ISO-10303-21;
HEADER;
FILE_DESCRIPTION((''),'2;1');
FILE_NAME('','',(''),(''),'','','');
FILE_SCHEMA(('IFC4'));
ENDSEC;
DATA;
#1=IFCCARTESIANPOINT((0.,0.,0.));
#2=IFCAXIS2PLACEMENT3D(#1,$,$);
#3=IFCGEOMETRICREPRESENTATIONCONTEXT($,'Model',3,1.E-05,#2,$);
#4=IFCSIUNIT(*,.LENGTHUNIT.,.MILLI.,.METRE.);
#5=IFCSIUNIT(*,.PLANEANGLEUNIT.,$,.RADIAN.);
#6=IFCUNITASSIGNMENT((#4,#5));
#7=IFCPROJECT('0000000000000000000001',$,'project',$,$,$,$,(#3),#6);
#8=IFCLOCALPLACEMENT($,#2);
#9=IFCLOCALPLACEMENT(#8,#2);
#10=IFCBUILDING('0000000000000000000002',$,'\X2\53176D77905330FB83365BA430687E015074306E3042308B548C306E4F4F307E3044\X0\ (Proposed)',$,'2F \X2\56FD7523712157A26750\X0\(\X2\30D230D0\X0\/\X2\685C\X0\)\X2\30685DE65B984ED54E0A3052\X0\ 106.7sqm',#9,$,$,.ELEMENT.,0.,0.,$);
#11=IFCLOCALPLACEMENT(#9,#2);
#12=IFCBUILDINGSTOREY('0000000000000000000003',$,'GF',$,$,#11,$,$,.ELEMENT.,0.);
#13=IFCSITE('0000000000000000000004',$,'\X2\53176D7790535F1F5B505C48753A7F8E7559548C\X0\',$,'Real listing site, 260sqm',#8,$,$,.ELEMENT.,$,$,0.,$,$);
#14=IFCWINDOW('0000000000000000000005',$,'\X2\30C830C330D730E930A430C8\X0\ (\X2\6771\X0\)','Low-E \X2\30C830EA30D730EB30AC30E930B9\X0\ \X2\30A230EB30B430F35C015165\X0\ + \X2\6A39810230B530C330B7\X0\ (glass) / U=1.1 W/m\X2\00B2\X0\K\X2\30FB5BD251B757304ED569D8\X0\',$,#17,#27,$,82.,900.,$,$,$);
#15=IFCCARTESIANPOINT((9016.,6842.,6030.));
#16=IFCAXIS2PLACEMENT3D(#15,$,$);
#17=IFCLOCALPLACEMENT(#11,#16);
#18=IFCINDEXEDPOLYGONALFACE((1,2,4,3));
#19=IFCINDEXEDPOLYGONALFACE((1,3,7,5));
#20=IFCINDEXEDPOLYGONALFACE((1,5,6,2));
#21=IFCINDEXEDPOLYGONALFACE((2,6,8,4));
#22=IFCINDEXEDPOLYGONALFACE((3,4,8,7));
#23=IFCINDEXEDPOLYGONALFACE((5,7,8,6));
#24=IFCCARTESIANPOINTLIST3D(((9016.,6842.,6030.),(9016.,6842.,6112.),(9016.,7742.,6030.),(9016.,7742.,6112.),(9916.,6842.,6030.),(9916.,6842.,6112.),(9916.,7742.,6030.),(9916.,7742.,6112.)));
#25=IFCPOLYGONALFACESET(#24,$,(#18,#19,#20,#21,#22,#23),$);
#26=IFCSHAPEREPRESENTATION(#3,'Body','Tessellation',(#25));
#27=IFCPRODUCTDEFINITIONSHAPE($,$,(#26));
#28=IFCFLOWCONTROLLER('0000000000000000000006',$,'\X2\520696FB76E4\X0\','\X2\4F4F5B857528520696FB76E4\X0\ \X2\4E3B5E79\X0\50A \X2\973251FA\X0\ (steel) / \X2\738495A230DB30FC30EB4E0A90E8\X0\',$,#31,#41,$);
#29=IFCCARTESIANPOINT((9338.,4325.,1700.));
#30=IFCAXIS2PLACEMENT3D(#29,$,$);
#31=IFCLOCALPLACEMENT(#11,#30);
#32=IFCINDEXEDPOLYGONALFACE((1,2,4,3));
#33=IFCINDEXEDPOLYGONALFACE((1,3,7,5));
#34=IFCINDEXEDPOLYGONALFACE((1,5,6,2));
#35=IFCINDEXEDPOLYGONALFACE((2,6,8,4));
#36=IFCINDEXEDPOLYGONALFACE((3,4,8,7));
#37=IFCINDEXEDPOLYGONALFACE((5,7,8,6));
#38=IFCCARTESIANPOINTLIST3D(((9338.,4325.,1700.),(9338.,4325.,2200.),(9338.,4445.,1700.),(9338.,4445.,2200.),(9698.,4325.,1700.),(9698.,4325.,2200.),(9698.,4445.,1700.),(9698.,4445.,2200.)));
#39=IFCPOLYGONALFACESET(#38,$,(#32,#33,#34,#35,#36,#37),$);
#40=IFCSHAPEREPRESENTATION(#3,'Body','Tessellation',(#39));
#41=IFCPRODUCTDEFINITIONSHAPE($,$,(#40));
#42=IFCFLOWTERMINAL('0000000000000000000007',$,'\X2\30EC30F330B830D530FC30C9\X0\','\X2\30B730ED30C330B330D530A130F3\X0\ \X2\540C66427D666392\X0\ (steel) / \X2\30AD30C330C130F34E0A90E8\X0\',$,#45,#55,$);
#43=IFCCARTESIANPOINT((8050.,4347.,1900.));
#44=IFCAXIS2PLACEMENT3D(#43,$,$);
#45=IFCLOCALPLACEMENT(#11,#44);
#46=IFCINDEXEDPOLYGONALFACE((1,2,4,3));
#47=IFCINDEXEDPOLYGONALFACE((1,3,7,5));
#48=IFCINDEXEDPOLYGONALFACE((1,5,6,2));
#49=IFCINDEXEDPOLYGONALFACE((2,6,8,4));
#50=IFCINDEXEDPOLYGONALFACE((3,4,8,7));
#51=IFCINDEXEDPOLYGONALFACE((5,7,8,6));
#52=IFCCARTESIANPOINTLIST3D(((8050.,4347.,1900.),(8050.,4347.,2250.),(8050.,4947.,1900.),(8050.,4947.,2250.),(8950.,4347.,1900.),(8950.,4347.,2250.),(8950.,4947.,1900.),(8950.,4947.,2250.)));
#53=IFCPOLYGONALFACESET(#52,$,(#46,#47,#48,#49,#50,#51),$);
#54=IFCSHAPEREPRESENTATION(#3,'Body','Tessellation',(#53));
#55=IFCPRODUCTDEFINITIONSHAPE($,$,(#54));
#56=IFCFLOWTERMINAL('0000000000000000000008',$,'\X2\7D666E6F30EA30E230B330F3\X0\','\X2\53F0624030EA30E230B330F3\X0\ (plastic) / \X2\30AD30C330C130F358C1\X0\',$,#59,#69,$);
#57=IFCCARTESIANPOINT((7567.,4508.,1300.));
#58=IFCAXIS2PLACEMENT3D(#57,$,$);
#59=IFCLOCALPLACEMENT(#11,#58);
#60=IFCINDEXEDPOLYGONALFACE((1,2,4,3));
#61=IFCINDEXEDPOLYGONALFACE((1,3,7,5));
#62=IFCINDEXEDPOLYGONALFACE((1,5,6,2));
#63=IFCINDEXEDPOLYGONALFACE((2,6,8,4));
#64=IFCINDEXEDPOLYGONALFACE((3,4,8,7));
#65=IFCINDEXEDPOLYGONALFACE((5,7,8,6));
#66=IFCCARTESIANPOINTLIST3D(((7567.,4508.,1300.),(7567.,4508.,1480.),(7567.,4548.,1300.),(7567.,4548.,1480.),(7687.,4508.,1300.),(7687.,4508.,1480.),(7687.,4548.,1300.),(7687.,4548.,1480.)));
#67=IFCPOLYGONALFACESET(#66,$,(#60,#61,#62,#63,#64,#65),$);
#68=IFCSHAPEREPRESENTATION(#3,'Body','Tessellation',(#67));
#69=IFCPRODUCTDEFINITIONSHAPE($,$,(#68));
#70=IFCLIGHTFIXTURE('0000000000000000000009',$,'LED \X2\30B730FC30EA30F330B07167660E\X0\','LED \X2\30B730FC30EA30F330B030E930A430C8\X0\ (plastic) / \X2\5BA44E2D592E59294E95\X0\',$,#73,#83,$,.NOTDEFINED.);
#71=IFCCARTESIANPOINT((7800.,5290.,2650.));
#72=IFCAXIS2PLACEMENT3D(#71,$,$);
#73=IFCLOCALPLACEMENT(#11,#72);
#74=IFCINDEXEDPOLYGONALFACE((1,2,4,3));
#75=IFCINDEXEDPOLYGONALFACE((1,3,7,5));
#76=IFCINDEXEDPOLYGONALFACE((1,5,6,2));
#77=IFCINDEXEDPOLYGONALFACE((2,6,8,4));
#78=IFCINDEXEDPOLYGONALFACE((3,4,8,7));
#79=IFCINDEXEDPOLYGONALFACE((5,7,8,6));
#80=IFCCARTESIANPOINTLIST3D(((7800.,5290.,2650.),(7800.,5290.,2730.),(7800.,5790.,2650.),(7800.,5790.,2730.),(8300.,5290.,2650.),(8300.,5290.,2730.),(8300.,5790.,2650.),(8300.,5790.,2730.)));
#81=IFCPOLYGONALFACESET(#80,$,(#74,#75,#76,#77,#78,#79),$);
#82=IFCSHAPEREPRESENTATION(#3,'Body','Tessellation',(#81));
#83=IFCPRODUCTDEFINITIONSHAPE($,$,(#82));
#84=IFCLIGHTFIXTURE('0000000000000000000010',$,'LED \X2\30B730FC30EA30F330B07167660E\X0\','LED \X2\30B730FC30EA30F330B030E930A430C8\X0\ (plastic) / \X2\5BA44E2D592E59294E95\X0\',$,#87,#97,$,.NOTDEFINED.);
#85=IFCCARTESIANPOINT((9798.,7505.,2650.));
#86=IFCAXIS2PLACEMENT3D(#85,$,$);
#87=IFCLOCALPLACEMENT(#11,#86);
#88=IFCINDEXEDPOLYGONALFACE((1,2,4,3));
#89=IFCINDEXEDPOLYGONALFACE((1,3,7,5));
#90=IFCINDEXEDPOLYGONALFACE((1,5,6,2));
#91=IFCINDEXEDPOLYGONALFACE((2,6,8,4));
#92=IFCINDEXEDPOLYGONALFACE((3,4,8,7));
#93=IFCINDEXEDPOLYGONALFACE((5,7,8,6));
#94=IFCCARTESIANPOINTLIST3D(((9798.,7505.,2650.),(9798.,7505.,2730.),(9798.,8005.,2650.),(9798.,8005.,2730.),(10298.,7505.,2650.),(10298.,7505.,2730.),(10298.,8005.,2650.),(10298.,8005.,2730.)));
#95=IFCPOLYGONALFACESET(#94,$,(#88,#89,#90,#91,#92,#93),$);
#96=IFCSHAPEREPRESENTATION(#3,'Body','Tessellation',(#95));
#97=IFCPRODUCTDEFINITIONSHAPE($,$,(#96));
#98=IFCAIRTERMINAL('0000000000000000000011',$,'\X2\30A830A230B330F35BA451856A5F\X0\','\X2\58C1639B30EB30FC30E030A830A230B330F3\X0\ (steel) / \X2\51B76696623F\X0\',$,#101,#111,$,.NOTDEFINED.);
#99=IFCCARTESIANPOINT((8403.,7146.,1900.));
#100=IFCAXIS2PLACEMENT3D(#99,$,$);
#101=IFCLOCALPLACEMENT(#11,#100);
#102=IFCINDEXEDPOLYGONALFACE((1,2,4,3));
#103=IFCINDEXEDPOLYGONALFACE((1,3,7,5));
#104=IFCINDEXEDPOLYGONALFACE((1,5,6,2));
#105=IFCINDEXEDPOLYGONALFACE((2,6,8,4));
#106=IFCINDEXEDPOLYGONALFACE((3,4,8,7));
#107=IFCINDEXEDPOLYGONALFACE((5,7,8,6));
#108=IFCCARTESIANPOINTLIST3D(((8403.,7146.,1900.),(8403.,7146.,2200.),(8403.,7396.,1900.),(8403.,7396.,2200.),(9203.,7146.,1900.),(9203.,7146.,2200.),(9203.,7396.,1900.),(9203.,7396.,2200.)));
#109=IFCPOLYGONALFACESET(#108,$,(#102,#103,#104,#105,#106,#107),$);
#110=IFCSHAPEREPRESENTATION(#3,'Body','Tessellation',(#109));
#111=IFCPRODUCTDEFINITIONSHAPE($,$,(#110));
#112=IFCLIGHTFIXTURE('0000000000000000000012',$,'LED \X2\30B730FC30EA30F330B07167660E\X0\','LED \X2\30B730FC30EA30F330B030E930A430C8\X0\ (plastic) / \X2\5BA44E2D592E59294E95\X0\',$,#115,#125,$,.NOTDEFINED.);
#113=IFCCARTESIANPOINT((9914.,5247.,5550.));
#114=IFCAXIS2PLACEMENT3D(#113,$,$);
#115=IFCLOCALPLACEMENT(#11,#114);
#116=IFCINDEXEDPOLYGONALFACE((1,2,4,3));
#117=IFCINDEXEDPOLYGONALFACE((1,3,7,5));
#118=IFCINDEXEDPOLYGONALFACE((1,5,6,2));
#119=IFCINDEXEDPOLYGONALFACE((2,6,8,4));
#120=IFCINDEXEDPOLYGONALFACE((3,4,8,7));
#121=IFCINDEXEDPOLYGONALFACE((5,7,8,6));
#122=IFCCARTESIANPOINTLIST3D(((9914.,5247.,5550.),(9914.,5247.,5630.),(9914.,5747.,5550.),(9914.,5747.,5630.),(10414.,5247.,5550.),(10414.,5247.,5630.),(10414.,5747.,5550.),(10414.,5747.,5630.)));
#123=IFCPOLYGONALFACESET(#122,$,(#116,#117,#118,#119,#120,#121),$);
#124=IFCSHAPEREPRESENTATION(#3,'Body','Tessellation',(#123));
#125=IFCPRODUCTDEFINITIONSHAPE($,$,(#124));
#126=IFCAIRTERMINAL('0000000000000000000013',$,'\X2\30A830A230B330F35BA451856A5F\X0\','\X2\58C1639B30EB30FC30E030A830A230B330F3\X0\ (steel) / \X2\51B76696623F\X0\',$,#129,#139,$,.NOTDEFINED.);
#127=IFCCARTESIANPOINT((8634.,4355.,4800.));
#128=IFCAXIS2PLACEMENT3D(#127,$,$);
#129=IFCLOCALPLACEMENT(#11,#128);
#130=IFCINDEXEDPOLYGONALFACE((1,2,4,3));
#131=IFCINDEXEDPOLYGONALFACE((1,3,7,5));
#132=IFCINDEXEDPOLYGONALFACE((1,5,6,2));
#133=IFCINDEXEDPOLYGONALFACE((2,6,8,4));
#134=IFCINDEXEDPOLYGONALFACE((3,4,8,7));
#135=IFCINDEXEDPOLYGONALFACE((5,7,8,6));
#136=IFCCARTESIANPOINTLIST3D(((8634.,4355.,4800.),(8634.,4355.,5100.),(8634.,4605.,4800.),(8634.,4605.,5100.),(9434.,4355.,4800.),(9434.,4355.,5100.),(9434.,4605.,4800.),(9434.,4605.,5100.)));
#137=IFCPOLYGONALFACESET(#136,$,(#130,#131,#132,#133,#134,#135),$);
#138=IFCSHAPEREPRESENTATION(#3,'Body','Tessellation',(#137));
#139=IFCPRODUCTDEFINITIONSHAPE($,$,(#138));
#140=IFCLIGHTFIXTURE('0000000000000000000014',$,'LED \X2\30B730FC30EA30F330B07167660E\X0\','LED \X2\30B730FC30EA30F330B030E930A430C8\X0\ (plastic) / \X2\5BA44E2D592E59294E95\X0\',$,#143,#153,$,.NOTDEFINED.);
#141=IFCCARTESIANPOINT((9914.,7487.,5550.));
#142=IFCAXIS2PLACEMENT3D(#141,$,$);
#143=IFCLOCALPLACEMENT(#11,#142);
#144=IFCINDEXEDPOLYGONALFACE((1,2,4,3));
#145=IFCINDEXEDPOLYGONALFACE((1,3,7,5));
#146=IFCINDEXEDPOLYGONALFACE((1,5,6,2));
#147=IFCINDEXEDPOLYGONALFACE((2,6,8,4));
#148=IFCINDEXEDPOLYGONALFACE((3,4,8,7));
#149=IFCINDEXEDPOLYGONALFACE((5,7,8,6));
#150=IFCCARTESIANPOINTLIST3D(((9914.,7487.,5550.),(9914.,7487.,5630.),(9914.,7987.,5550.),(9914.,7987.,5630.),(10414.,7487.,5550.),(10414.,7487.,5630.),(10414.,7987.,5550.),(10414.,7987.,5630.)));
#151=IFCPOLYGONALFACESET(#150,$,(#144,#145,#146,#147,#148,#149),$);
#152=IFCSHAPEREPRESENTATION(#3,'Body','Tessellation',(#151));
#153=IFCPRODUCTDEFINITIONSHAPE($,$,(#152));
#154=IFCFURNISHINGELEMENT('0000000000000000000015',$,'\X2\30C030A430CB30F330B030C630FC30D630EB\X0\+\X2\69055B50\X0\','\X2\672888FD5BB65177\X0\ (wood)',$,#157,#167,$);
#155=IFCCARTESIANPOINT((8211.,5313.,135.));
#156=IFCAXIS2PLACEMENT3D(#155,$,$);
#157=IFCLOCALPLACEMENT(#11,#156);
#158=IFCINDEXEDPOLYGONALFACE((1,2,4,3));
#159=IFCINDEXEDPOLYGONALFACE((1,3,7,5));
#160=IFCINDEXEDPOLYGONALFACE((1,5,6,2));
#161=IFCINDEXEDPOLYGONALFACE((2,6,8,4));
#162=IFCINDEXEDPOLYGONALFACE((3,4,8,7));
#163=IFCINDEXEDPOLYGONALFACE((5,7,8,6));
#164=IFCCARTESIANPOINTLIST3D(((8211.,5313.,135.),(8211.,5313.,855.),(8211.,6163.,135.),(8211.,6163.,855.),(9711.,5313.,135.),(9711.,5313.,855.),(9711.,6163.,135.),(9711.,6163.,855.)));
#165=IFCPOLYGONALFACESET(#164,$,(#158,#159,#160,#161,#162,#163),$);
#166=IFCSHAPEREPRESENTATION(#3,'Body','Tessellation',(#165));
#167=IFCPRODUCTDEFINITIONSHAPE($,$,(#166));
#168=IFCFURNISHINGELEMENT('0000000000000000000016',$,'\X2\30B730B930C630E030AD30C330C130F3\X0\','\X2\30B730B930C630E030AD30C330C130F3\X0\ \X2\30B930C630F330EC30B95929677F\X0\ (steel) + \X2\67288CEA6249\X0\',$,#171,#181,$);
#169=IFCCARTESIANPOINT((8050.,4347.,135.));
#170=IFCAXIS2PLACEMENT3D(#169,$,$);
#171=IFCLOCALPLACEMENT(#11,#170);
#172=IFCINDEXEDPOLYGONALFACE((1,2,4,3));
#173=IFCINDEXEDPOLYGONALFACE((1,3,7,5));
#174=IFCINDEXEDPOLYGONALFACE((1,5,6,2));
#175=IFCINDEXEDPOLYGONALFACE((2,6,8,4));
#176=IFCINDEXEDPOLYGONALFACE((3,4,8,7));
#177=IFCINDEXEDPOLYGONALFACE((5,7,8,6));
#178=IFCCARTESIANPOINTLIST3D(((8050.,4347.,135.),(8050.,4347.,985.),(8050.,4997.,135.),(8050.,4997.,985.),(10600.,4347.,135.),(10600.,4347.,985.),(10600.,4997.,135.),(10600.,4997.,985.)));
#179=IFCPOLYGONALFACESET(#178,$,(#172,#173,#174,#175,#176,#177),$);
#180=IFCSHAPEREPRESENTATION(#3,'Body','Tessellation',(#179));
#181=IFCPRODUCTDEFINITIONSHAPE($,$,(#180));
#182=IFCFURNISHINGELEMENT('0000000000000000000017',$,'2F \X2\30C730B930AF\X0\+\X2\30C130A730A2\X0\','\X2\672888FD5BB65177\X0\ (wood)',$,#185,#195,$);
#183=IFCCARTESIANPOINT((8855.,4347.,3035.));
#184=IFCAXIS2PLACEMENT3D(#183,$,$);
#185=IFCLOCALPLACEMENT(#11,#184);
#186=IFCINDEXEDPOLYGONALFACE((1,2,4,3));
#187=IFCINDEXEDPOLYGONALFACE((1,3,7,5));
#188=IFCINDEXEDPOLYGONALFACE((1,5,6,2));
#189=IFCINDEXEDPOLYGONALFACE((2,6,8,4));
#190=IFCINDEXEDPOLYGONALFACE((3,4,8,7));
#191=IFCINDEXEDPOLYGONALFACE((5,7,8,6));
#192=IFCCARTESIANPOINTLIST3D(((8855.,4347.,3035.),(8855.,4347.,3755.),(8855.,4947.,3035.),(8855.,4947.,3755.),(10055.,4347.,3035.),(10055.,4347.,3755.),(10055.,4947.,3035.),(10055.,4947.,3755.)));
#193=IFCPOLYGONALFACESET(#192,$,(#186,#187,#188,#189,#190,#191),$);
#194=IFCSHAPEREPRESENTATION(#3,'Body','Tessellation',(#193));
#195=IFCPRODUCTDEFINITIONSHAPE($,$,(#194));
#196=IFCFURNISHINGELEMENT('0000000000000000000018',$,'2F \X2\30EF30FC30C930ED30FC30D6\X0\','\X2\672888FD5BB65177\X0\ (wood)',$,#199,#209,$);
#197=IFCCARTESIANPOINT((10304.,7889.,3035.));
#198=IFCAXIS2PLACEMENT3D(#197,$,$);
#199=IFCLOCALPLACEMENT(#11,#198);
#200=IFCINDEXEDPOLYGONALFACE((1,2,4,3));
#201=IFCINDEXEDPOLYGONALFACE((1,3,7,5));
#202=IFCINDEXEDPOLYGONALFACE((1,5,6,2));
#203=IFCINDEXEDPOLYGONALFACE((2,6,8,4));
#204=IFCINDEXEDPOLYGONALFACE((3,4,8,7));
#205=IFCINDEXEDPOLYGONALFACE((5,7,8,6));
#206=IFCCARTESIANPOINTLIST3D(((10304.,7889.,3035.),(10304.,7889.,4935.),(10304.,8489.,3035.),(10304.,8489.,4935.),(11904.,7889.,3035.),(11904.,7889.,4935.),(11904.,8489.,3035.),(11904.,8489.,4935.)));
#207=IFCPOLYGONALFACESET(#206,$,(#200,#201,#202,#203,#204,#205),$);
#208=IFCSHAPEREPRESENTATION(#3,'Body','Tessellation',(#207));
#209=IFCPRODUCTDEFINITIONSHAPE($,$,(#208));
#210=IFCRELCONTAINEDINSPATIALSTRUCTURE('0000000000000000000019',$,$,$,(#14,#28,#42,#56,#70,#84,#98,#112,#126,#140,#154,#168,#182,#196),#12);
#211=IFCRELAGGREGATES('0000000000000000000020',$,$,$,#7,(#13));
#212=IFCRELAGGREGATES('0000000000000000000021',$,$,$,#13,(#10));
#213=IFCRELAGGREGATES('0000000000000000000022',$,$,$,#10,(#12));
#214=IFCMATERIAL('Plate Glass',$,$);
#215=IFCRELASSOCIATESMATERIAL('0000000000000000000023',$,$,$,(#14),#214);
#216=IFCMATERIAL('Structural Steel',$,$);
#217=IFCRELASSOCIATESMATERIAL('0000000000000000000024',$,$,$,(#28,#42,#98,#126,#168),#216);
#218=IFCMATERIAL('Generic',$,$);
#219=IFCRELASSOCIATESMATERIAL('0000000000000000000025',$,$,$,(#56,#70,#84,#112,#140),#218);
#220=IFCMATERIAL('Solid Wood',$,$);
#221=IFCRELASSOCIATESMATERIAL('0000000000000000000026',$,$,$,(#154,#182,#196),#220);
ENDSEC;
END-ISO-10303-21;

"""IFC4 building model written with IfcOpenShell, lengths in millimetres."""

from ifc_helpers import new_model, si_unit, frame, frame_2d, origin, place, context, project, spatial, rectangle, extrude, material, element, save


model = new_model("IFC4")

# Units and contexts
model_context = context("Model", 3, precision=1e-05, world=origin())
ifc_project = project(units=[si_unit("LENGTHUNIT", "METRE", prefix="MILLI"), si_unit("PLANEANGLEUNIT", "RADIAN")], contexts=[model_context])

# Site, building, storey
site_placement = place(None, origin())
site = spatial("IfcSite", under=ifc_project, at=site_placement, Name="北海道弟子屈町美留和", ObjectType="Real listing site, 260sqm", CompositionType="ELEMENT", RefElevation=0.0)
building_placement = place(site_placement, origin())
building = spatial("IfcBuilding", under=site, at=building_placement, Name="北海道・茶室と縁側のある和の住まい (Proposed)", ObjectType="2F 国産無垢材(ヒバ/桜)と左官仕上げ 106.7sqm", CompositionType="ELEMENT", ElevationOfRefHeight=0.0, ElevationOfTerrain=0.0)
storey_placement = place(building_placement, origin())
storey = spatial("IfcBuildingStorey", under=building, at=storey_placement, Name="GF", CompositionType="ELEMENT", Elevation=0.0)

# Shared definitions
ifc_material_1 = material(Name="Solid Wood")

# Window
ifc_material_2 = material(Name="Plate Glass")
window_placement = place(storey_placement, frame((9016.0, 6842.0, 6030.0)))
element("IfcWindow", 1, at=window_placement, inside=storey, material=ifc_material_2, Name="トップライト (東)", Description="Low-E トリプルガラス アルゴン封入 + 樹脂サッシ (glass) / U=1.1 W/m²K・寒冷地仕様", OverallHeight=82.0, OverallWidth=900.0, context=model_context, shape_type="SweptSolid", body=[
    extrude(rectangle(XDim=900.0, YDim=900.0, at=frame_2d((450.0, 450.0))), frame((9016.0, 6842.0, 6030.0)), (0.0, 0.0, 1.0), 82.0),
])

# Flow controller
ifc_material_3 = material(Name="Structural Steel")
flow_controller_placement = place(storey_placement, frame((9338.0, 4325.0, 1700.0)))
element("IfcFlowController", 2, at=flow_controller_placement, inside=storey, material=ifc_material_3, Name="分電盤", Description="住宅用分電盤 主幹50A 露出 (steel) / 玄関ホール上部", context=model_context, shape_type="SweptSolid", body=[
    extrude(rectangle(XDim=360.0, YDim=120.0, at=frame_2d((180.0, 60.0))), frame((9338.0, 4325.0, 1700.0)), (0.0, 0.0, 1.0), 500.0),
])

# Flow terminals
flow_terminal_1_placement = place(storey_placement, frame((8050.0, 4347.0, 1900.0)))
element("IfcFlowTerminal", 3, at=flow_terminal_1_placement, inside=storey, material=ifc_material_3, Name="レンジフード", Description="シロッコファン 同時給排 (steel) / キッチン上部", context=model_context, shape_type="SweptSolid", body=[
    extrude(rectangle(XDim=900.0, YDim=600.0, at=frame_2d((450.0, 300.0))), frame((8050.0, 4347.0, 1900.0)), (0.0, 0.0, 1.0), 350.0),
])
ifc_material_4 = material(Name="Generic")
flow_terminal_2_placement = place(storey_placement, frame((7567.0, 4508.0, 1300.0)))
element("IfcFlowTerminal", 4, at=flow_terminal_2_placement, inside=storey, material=ifc_material_4, Name="給湯リモコン", Description="台所リモコン (plastic) / キッチン壁", context=model_context, shape_type="SweptSolid", body=[
    extrude(rectangle(XDim=120.0, YDim=40.0, at=frame_2d((60.0, 20.0))), frame((7567.0, 4508.0, 1300.0)), (0.0, 0.0, 1.0), 180.0),
])

# Light fixtures
light_fixture_1_placement = place(storey_placement, frame((7800.0, 5290.0, 2650.0)))
element("IfcLightFixture", 5, at=light_fixture_1_placement, inside=storey, material=ifc_material_4, Name="LED シーリング照明", Description="LED シーリングライト (plastic) / 室中央天井", PredefinedType="NOTDEFINED", context=model_context, shape_type="SweptSolid", body=[
    extrude(rectangle(XDim=500.0, YDim=500.0, at=frame_2d((250.0, 250.0))), frame((7800.0, 5290.0, 2650.0)), (0.0, 0.0, 1.0), 80.0),
])
light_fixture_2_placement = place(storey_placement, frame((9798.0, 7505.0, 2650.0)))
element("IfcLightFixture", 6, at=light_fixture_2_placement, inside=storey, material=ifc_material_4, Name="LED シーリング照明", Description="LED シーリングライト (plastic) / 室中央天井", PredefinedType="NOTDEFINED", context=model_context, shape_type="SweptSolid", body=[
    extrude(rectangle(XDim=500.0, YDim=500.0, at=frame_2d((250.0, 250.0))), frame((9798.0, 7505.0, 2650.0)), (0.0, 0.0, 1.0), 80.0),
])

# Air terminal
air_terminal_1_placement = place(storey_placement, frame((8403.0, 7146.0, 1900.0)))
element("IfcAirTerminal", 7, at=air_terminal_1_placement, inside=storey, material=ifc_material_3, Name="エアコン室内機", Description="壁掛ルームエアコン (steel) / 冷暖房", PredefinedType="NOTDEFINED", context=model_context, shape_type="SweptSolid", body=[
    extrude(rectangle(XDim=800.0, YDim=250.0, at=frame_2d((400.0, 125.0))), frame((8403.0, 7146.0, 1900.0)), (0.0, 0.0, 1.0), 300.0),
])

# Light fixture
light_fixture_3_placement = place(storey_placement, frame((9914.0, 5247.0, 5550.0)))
element("IfcLightFixture", 8, at=light_fixture_3_placement, inside=storey, material=ifc_material_4, Name="LED シーリング照明", Description="LED シーリングライト (plastic) / 室中央天井", PredefinedType="NOTDEFINED", context=model_context, shape_type="SweptSolid", body=[
    extrude(rectangle(XDim=500.0, YDim=500.0, at=frame_2d((250.0, 250.0))), frame((9914.0, 5247.0, 5550.0)), (0.0, 0.0, 1.0), 80.0),
])

# Air terminal
air_terminal_2_placement = place(storey_placement, frame((8634.0, 4355.0, 4800.0)))
element("IfcAirTerminal", 9, at=air_terminal_2_placement, inside=storey, material=ifc_material_3, Name="エアコン室内機", Description="壁掛ルームエアコン (steel) / 冷暖房", PredefinedType="NOTDEFINED", context=model_context, shape_type="SweptSolid", body=[
    extrude(rectangle(XDim=800.0, YDim=250.0, at=frame_2d((400.0, 125.0))), frame((8634.0, 4355.0, 4800.0)), (0.0, 0.0, 1.0), 300.0),
])

# Light fixture
light_fixture_4_placement = place(storey_placement, frame((9914.0, 7487.0, 5550.0)))
element("IfcLightFixture", 10, at=light_fixture_4_placement, inside=storey, material=ifc_material_4, Name="LED シーリング照明", Description="LED シーリングライト (plastic) / 室中央天井", PredefinedType="NOTDEFINED", context=model_context, shape_type="SweptSolid", body=[
    extrude(rectangle(XDim=500.0, YDim=500.0, at=frame_2d((250.0, 250.0))), frame((9914.0, 7487.0, 5550.0)), (0.0, 0.0, 1.0), 80.0),
])

# Furnishing elements
furnishing_1_placement = place(storey_placement, frame((8211.0, 5313.0, 135.0)))
element("IfcFurnishingElement", 11, at=furnishing_1_placement, inside=storey, material=ifc_material_1, Name="ダイニングテーブル+椅子", Description="木製家具 (wood)", context=model_context, shape_type="SweptSolid", body=[
    extrude(rectangle(XDim=1500.0, YDim=850.0, at=frame_2d((750.0, 425.0))), frame((8211.0, 5313.0, 135.0)), (0.0, 0.0, 1.0), 720.0),
])
furnishing_2_placement = place(storey_placement, frame((8050.0, 4347.0, 135.0)))
element("IfcFurnishingElement", 12, at=furnishing_2_placement, inside=storey, material=ifc_material_3, Name="システムキッチン", Description="システムキッチン ステンレス天板 (steel) + 木質扉", context=model_context, shape_type="SweptSolid", body=[
    extrude(rectangle(XDim=2550.0, YDim=650.0, at=frame_2d((1275.0, 325.0))), frame((8050.0, 4347.0, 135.0)), (0.0, 0.0, 1.0), 850.0),
])
furnishing_3_placement = place(storey_placement, frame((8855.0, 4347.0, 3035.0)))
element("IfcFurnishingElement", 13, at=furnishing_3_placement, inside=storey, material=ifc_material_1, Name="2F デスク+チェア", Description="木製家具 (wood)", context=model_context, shape_type="SweptSolid", body=[
    extrude(rectangle(XDim=1200.0, YDim=600.0, at=frame_2d((600.0, 300.0))), frame((8855.0, 4347.0, 3035.0)), (0.0, 0.0, 1.0), 720.0),
])
furnishing_4_placement = place(storey_placement, frame((10304.0, 7889.0, 3035.0)))
element("IfcFurnishingElement", 14, at=furnishing_4_placement, inside=storey, material=ifc_material_1, Name="2F ワードローブ", Description="木製家具 (wood)", context=model_context, shape_type="SweptSolid", body=[
    extrude(rectangle(XDim=1600.0, YDim=600.0, at=frame_2d((800.0, 300.0))), frame((10304.0, 7889.0, 3035.0)), (0.0, 0.0, 1.0), 1900.0),
])

save(model, "model.ifc")
